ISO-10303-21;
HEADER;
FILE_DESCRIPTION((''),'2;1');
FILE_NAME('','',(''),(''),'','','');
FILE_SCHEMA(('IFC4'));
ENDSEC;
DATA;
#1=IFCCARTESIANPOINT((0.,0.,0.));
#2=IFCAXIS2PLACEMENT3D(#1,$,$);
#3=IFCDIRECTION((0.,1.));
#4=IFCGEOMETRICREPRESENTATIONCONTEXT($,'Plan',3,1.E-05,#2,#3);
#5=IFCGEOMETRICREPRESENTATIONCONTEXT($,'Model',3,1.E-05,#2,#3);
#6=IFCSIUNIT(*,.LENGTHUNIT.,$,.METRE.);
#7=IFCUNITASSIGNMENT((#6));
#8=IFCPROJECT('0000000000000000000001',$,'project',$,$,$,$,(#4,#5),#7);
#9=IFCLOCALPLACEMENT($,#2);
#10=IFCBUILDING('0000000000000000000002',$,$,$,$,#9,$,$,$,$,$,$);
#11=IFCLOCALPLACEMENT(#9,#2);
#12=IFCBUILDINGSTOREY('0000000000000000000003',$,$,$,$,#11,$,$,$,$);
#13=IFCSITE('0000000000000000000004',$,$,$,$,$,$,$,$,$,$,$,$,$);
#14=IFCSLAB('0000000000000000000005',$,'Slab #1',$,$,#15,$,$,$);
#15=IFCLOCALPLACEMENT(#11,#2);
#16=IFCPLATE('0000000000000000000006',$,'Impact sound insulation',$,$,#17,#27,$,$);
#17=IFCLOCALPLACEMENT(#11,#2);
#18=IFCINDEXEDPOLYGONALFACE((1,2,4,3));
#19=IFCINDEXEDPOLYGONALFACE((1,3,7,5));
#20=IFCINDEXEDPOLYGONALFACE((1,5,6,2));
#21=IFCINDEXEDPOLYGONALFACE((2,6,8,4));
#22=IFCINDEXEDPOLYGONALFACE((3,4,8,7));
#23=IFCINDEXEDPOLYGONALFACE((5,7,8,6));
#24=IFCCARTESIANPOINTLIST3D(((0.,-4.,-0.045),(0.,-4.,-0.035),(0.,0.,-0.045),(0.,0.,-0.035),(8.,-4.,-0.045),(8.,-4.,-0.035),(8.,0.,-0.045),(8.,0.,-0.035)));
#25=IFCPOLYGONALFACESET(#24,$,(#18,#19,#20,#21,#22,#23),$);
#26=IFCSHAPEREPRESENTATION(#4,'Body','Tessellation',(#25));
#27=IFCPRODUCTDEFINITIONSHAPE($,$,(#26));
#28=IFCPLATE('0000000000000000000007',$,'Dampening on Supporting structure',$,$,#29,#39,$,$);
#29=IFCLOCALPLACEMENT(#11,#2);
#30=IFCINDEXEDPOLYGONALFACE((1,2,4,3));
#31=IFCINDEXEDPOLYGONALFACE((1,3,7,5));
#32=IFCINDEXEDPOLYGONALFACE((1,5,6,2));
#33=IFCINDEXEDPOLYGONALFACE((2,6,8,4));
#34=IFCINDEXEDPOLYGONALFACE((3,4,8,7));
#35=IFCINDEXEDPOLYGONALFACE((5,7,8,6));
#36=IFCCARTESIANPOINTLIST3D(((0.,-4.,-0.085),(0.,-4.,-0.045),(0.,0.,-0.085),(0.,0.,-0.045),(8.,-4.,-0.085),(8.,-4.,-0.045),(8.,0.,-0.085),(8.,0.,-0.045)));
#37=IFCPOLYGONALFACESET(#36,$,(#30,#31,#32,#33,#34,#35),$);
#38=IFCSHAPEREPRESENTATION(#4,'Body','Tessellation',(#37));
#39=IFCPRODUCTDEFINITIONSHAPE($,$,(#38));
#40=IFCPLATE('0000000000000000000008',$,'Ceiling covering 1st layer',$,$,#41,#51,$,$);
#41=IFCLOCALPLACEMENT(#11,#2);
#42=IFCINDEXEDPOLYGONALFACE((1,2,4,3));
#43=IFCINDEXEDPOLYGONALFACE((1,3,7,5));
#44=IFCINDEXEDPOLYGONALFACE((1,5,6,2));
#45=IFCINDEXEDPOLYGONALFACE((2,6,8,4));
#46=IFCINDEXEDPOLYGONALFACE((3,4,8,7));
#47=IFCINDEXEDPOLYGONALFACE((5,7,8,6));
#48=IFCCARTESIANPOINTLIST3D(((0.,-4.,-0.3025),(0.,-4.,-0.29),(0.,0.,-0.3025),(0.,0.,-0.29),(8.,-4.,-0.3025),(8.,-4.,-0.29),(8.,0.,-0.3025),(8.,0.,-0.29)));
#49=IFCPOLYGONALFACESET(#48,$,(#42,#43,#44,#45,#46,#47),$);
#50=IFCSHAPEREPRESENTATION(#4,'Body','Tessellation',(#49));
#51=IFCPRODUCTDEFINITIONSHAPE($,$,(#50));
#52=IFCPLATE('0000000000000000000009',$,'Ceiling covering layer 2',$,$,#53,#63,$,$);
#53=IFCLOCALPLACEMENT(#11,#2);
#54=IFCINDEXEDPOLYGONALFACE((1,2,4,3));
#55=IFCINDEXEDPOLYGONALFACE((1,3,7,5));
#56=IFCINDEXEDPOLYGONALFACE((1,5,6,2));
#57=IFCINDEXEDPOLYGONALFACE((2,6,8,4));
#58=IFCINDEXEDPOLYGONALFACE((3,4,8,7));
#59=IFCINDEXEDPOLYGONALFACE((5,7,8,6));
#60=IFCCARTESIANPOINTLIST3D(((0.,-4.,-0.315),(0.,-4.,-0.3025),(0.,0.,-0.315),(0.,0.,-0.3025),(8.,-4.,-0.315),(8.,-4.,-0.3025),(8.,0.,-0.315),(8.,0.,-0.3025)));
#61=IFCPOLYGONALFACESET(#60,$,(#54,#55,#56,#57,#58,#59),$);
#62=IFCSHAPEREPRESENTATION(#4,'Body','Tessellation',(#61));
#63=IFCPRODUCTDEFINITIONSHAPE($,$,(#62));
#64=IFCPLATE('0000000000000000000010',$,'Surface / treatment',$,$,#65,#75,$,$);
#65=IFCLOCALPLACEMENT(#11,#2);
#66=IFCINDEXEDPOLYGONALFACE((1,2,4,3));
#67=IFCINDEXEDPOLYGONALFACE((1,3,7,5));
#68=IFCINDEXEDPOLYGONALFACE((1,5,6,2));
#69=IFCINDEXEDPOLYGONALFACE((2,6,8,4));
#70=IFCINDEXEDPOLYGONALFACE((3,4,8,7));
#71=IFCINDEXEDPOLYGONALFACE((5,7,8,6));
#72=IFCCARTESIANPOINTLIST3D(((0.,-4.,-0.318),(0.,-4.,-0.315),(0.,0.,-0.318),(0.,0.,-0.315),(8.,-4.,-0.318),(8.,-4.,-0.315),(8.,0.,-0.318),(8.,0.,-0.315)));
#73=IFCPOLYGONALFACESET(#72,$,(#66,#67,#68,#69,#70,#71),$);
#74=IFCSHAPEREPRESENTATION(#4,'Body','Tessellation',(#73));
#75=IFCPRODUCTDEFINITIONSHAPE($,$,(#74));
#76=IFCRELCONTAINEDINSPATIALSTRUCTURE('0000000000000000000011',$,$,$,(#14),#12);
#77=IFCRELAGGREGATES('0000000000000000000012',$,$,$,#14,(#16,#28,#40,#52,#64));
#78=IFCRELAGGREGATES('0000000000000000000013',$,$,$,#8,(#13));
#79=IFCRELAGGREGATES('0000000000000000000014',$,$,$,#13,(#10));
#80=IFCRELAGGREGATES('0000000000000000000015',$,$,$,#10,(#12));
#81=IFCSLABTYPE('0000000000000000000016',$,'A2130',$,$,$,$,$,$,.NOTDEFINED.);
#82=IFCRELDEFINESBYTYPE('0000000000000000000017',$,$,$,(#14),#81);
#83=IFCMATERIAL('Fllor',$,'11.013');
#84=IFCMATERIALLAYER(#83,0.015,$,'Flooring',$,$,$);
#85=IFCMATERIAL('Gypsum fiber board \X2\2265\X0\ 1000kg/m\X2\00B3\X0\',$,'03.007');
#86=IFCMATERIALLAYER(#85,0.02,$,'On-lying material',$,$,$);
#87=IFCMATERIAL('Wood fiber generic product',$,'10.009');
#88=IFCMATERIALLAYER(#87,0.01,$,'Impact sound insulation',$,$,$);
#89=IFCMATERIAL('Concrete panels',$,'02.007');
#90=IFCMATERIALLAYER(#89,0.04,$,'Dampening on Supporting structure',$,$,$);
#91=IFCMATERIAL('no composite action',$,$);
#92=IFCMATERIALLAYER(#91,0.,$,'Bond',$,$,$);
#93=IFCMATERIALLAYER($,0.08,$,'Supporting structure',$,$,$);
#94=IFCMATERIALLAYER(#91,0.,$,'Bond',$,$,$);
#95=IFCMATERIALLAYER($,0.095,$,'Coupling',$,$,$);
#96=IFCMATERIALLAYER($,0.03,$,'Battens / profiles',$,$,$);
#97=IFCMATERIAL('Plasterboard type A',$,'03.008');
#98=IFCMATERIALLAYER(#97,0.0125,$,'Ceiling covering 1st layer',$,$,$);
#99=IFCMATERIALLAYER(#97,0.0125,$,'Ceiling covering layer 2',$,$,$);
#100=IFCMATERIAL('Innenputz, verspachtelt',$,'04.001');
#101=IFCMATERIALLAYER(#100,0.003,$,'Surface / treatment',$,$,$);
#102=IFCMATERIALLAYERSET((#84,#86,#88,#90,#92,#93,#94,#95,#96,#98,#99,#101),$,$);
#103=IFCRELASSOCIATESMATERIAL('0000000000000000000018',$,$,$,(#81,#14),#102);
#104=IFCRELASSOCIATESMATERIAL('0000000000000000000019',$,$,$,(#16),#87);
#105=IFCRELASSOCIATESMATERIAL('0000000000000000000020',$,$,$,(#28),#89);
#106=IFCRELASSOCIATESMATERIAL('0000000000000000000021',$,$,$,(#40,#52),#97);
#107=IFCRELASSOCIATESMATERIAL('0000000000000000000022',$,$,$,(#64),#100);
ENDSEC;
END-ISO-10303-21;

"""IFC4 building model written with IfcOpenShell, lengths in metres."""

from ifc_helpers import new_model, si_unit, direction, frame, frame_2d, origin, place, context, project, spatial, rectangle, extrude, material, layer, layer_set, type_object, element, aggregate, save


model = new_model("IFC4")

# Units and contexts
plan_context = context("Plan", 3, precision=1e-05, world=origin(), true_north=direction((0.0, 1.0)))
model_context = context("Model", 3, precision=1e-05, world=origin(), true_north=direction((0.0, 1.0)))
ifc_project = project(units=[si_unit("LENGTHUNIT", "METRE")], contexts=[plan_context, model_context])

# Site, building, storey
site = spatial("IfcSite", under=ifc_project)
building_placement = place(None, origin())
building = spatial("IfcBuilding", under=site, at=building_placement)
storey_placement = place(building_placement, origin())
storey = spatial("IfcBuildingStorey", under=building, at=storey_placement)

# Slab, plates
ifc_material_1 = material(Name="Fllor", Category="11.013")
ifc_layer_1 = layer(ifc_material_1, 0.015, Name="Flooring")
ifc_material_2 = material(Name="Gypsum fiber board ≥ 1000kg/m³", Category="03.007")
ifc_layer_2 = layer(ifc_material_2, 0.02, Name="On-lying material")
ifc_material_3 = material(Name="Wood fiber generic product", Category="10.009")
ifc_layer_3 = layer(ifc_material_3, 0.01, Name="Impact sound insulation")
ifc_material_4 = material(Name="Concrete panels", Category="02.007")
ifc_layer_4 = layer(ifc_material_4, 0.04, Name="Dampening on Supporting structure")
ifc_material_5 = material(Name="no composite action")
ifc_layer_5 = layer(ifc_material_5, 0.0, Name="Bond")
ifc_layer_6 = layer(None, 0.08, Name="Supporting structure")
ifc_layer_7 = layer(ifc_material_5, 0.0, Name="Bond")
ifc_layer_8 = layer(None, 0.095, Name="Coupling")
ifc_layer_9 = layer(None, 0.03, Name="Battens / profiles")
ifc_material_6 = material(Name="Plasterboard type A", Category="03.008")
ifc_layer_10 = layer(ifc_material_6, 0.0125, Name="Ceiling covering 1st layer")
ifc_layer_11 = layer(ifc_material_6, 0.0125, Name="Ceiling covering layer 2")
ifc_material_7 = material(Name="Innenputz, verspachtelt", Category="04.001")
ifc_layer_12 = layer(ifc_material_7, 0.003, Name="Surface / treatment")
ifc_layer_set = layer_set([ifc_layer_1, ifc_layer_2, ifc_layer_3, ifc_layer_4, ifc_layer_5, ifc_layer_6, ifc_layer_7, ifc_layer_8, ifc_layer_9, ifc_layer_10, ifc_layer_11, ifc_layer_12])
slab_type = type_object("IfcSlabType", Name="A2130", PredefinedType="NOTDEFINED", material=ifc_layer_set)
slab_placement = place(None, frame((0.0, 0.0, 0.0), z_axis=(0.0, 0.0, -1.0), x_axis=(1.0, 0.0, 0.0)))
slab = element("IfcSlab", 1, at=slab_placement, inside=storey, type_object=slab_type, material=ifc_layer_set, Name="Slab #1")
plate_1_placement = place(slab_placement, origin())
plate_1 = element("IfcPlate", 2, at=plate_1_placement, material=ifc_material_3, Name="Impact sound insulation", context=plan_context, shape_type="SweptSolid", body=[
    extrude(rectangle(XDim=8.0, YDim=4.0, at=frame_2d((4.0, 2.0), x_axis=(1.0, 0.0))), frame((0.0, 0.0, 0.035), z_axis=(0.0, 0.0, 1.0), x_axis=(1.0, 0.0, 0.0)), (0.0, 0.0, 1.0), 0.01),
])
plate_2_placement = place(slab_placement, origin())
plate_2 = element("IfcPlate", 3, at=plate_2_placement, material=ifc_material_4, Name="Dampening on Supporting structure", context=plan_context, shape_type="SweptSolid", body=[
    extrude(rectangle(XDim=8.0, YDim=4.0, at=frame_2d((4.0, 2.0), x_axis=(1.0, 0.0))), frame((0.0, 0.0, 0.045), z_axis=(0.0, 0.0, 1.0), x_axis=(1.0, 0.0, 0.0)), (0.0, 0.0, 1.0), 0.04),
])
plate_3_placement = place(slab_placement, origin())
plate_3 = element("IfcPlate", 4, at=plate_3_placement, material=ifc_material_6, Name="Ceiling covering 1st layer", context=plan_context, shape_type="SweptSolid", body=[
    extrude(rectangle(XDim=8.0, YDim=4.0, at=frame_2d((4.0, 2.0), x_axis=(1.0, 0.0))), frame((0.0, 0.0, 0.29), z_axis=(0.0, 0.0, 1.0), x_axis=(1.0, 0.0, 0.0)), (0.0, 0.0, 1.0), 0.0125),
])
plate_4_placement = place(slab_placement, origin())
plate_4 = element("IfcPlate", 5, at=plate_4_placement, material=ifc_material_6, Name="Ceiling covering layer 2", context=plan_context, shape_type="SweptSolid", body=[
    extrude(rectangle(XDim=8.0, YDim=4.0, at=frame_2d((4.0, 2.0), x_axis=(1.0, 0.0))), frame((0.0, 0.0, 0.3025), z_axis=(0.0, 0.0, 1.0), x_axis=(1.0, 0.0, 0.0)), (0.0, 0.0, 1.0), 0.0125),
])
plate_5_placement = place(slab_placement, origin())
plate_5 = element("IfcPlate", 6, at=plate_5_placement, material=ifc_material_7, Name="Surface / treatment", context=plan_context, shape_type="SweptSolid", body=[
    extrude(rectangle(XDim=8.0, YDim=4.0, at=frame_2d((4.0, 2.0), x_axis=(1.0, 0.0))), frame((0.0, 0.0, 0.315), z_axis=(0.0, 0.0, 1.0), x_axis=(1.0, 0.0, 0.0)), (0.0, 0.0, 1.0), 0.003),
])
aggregate(slab, [plate_1, plate_2, plate_3, plate_4, plate_5])

save(model, "model.ifc")
